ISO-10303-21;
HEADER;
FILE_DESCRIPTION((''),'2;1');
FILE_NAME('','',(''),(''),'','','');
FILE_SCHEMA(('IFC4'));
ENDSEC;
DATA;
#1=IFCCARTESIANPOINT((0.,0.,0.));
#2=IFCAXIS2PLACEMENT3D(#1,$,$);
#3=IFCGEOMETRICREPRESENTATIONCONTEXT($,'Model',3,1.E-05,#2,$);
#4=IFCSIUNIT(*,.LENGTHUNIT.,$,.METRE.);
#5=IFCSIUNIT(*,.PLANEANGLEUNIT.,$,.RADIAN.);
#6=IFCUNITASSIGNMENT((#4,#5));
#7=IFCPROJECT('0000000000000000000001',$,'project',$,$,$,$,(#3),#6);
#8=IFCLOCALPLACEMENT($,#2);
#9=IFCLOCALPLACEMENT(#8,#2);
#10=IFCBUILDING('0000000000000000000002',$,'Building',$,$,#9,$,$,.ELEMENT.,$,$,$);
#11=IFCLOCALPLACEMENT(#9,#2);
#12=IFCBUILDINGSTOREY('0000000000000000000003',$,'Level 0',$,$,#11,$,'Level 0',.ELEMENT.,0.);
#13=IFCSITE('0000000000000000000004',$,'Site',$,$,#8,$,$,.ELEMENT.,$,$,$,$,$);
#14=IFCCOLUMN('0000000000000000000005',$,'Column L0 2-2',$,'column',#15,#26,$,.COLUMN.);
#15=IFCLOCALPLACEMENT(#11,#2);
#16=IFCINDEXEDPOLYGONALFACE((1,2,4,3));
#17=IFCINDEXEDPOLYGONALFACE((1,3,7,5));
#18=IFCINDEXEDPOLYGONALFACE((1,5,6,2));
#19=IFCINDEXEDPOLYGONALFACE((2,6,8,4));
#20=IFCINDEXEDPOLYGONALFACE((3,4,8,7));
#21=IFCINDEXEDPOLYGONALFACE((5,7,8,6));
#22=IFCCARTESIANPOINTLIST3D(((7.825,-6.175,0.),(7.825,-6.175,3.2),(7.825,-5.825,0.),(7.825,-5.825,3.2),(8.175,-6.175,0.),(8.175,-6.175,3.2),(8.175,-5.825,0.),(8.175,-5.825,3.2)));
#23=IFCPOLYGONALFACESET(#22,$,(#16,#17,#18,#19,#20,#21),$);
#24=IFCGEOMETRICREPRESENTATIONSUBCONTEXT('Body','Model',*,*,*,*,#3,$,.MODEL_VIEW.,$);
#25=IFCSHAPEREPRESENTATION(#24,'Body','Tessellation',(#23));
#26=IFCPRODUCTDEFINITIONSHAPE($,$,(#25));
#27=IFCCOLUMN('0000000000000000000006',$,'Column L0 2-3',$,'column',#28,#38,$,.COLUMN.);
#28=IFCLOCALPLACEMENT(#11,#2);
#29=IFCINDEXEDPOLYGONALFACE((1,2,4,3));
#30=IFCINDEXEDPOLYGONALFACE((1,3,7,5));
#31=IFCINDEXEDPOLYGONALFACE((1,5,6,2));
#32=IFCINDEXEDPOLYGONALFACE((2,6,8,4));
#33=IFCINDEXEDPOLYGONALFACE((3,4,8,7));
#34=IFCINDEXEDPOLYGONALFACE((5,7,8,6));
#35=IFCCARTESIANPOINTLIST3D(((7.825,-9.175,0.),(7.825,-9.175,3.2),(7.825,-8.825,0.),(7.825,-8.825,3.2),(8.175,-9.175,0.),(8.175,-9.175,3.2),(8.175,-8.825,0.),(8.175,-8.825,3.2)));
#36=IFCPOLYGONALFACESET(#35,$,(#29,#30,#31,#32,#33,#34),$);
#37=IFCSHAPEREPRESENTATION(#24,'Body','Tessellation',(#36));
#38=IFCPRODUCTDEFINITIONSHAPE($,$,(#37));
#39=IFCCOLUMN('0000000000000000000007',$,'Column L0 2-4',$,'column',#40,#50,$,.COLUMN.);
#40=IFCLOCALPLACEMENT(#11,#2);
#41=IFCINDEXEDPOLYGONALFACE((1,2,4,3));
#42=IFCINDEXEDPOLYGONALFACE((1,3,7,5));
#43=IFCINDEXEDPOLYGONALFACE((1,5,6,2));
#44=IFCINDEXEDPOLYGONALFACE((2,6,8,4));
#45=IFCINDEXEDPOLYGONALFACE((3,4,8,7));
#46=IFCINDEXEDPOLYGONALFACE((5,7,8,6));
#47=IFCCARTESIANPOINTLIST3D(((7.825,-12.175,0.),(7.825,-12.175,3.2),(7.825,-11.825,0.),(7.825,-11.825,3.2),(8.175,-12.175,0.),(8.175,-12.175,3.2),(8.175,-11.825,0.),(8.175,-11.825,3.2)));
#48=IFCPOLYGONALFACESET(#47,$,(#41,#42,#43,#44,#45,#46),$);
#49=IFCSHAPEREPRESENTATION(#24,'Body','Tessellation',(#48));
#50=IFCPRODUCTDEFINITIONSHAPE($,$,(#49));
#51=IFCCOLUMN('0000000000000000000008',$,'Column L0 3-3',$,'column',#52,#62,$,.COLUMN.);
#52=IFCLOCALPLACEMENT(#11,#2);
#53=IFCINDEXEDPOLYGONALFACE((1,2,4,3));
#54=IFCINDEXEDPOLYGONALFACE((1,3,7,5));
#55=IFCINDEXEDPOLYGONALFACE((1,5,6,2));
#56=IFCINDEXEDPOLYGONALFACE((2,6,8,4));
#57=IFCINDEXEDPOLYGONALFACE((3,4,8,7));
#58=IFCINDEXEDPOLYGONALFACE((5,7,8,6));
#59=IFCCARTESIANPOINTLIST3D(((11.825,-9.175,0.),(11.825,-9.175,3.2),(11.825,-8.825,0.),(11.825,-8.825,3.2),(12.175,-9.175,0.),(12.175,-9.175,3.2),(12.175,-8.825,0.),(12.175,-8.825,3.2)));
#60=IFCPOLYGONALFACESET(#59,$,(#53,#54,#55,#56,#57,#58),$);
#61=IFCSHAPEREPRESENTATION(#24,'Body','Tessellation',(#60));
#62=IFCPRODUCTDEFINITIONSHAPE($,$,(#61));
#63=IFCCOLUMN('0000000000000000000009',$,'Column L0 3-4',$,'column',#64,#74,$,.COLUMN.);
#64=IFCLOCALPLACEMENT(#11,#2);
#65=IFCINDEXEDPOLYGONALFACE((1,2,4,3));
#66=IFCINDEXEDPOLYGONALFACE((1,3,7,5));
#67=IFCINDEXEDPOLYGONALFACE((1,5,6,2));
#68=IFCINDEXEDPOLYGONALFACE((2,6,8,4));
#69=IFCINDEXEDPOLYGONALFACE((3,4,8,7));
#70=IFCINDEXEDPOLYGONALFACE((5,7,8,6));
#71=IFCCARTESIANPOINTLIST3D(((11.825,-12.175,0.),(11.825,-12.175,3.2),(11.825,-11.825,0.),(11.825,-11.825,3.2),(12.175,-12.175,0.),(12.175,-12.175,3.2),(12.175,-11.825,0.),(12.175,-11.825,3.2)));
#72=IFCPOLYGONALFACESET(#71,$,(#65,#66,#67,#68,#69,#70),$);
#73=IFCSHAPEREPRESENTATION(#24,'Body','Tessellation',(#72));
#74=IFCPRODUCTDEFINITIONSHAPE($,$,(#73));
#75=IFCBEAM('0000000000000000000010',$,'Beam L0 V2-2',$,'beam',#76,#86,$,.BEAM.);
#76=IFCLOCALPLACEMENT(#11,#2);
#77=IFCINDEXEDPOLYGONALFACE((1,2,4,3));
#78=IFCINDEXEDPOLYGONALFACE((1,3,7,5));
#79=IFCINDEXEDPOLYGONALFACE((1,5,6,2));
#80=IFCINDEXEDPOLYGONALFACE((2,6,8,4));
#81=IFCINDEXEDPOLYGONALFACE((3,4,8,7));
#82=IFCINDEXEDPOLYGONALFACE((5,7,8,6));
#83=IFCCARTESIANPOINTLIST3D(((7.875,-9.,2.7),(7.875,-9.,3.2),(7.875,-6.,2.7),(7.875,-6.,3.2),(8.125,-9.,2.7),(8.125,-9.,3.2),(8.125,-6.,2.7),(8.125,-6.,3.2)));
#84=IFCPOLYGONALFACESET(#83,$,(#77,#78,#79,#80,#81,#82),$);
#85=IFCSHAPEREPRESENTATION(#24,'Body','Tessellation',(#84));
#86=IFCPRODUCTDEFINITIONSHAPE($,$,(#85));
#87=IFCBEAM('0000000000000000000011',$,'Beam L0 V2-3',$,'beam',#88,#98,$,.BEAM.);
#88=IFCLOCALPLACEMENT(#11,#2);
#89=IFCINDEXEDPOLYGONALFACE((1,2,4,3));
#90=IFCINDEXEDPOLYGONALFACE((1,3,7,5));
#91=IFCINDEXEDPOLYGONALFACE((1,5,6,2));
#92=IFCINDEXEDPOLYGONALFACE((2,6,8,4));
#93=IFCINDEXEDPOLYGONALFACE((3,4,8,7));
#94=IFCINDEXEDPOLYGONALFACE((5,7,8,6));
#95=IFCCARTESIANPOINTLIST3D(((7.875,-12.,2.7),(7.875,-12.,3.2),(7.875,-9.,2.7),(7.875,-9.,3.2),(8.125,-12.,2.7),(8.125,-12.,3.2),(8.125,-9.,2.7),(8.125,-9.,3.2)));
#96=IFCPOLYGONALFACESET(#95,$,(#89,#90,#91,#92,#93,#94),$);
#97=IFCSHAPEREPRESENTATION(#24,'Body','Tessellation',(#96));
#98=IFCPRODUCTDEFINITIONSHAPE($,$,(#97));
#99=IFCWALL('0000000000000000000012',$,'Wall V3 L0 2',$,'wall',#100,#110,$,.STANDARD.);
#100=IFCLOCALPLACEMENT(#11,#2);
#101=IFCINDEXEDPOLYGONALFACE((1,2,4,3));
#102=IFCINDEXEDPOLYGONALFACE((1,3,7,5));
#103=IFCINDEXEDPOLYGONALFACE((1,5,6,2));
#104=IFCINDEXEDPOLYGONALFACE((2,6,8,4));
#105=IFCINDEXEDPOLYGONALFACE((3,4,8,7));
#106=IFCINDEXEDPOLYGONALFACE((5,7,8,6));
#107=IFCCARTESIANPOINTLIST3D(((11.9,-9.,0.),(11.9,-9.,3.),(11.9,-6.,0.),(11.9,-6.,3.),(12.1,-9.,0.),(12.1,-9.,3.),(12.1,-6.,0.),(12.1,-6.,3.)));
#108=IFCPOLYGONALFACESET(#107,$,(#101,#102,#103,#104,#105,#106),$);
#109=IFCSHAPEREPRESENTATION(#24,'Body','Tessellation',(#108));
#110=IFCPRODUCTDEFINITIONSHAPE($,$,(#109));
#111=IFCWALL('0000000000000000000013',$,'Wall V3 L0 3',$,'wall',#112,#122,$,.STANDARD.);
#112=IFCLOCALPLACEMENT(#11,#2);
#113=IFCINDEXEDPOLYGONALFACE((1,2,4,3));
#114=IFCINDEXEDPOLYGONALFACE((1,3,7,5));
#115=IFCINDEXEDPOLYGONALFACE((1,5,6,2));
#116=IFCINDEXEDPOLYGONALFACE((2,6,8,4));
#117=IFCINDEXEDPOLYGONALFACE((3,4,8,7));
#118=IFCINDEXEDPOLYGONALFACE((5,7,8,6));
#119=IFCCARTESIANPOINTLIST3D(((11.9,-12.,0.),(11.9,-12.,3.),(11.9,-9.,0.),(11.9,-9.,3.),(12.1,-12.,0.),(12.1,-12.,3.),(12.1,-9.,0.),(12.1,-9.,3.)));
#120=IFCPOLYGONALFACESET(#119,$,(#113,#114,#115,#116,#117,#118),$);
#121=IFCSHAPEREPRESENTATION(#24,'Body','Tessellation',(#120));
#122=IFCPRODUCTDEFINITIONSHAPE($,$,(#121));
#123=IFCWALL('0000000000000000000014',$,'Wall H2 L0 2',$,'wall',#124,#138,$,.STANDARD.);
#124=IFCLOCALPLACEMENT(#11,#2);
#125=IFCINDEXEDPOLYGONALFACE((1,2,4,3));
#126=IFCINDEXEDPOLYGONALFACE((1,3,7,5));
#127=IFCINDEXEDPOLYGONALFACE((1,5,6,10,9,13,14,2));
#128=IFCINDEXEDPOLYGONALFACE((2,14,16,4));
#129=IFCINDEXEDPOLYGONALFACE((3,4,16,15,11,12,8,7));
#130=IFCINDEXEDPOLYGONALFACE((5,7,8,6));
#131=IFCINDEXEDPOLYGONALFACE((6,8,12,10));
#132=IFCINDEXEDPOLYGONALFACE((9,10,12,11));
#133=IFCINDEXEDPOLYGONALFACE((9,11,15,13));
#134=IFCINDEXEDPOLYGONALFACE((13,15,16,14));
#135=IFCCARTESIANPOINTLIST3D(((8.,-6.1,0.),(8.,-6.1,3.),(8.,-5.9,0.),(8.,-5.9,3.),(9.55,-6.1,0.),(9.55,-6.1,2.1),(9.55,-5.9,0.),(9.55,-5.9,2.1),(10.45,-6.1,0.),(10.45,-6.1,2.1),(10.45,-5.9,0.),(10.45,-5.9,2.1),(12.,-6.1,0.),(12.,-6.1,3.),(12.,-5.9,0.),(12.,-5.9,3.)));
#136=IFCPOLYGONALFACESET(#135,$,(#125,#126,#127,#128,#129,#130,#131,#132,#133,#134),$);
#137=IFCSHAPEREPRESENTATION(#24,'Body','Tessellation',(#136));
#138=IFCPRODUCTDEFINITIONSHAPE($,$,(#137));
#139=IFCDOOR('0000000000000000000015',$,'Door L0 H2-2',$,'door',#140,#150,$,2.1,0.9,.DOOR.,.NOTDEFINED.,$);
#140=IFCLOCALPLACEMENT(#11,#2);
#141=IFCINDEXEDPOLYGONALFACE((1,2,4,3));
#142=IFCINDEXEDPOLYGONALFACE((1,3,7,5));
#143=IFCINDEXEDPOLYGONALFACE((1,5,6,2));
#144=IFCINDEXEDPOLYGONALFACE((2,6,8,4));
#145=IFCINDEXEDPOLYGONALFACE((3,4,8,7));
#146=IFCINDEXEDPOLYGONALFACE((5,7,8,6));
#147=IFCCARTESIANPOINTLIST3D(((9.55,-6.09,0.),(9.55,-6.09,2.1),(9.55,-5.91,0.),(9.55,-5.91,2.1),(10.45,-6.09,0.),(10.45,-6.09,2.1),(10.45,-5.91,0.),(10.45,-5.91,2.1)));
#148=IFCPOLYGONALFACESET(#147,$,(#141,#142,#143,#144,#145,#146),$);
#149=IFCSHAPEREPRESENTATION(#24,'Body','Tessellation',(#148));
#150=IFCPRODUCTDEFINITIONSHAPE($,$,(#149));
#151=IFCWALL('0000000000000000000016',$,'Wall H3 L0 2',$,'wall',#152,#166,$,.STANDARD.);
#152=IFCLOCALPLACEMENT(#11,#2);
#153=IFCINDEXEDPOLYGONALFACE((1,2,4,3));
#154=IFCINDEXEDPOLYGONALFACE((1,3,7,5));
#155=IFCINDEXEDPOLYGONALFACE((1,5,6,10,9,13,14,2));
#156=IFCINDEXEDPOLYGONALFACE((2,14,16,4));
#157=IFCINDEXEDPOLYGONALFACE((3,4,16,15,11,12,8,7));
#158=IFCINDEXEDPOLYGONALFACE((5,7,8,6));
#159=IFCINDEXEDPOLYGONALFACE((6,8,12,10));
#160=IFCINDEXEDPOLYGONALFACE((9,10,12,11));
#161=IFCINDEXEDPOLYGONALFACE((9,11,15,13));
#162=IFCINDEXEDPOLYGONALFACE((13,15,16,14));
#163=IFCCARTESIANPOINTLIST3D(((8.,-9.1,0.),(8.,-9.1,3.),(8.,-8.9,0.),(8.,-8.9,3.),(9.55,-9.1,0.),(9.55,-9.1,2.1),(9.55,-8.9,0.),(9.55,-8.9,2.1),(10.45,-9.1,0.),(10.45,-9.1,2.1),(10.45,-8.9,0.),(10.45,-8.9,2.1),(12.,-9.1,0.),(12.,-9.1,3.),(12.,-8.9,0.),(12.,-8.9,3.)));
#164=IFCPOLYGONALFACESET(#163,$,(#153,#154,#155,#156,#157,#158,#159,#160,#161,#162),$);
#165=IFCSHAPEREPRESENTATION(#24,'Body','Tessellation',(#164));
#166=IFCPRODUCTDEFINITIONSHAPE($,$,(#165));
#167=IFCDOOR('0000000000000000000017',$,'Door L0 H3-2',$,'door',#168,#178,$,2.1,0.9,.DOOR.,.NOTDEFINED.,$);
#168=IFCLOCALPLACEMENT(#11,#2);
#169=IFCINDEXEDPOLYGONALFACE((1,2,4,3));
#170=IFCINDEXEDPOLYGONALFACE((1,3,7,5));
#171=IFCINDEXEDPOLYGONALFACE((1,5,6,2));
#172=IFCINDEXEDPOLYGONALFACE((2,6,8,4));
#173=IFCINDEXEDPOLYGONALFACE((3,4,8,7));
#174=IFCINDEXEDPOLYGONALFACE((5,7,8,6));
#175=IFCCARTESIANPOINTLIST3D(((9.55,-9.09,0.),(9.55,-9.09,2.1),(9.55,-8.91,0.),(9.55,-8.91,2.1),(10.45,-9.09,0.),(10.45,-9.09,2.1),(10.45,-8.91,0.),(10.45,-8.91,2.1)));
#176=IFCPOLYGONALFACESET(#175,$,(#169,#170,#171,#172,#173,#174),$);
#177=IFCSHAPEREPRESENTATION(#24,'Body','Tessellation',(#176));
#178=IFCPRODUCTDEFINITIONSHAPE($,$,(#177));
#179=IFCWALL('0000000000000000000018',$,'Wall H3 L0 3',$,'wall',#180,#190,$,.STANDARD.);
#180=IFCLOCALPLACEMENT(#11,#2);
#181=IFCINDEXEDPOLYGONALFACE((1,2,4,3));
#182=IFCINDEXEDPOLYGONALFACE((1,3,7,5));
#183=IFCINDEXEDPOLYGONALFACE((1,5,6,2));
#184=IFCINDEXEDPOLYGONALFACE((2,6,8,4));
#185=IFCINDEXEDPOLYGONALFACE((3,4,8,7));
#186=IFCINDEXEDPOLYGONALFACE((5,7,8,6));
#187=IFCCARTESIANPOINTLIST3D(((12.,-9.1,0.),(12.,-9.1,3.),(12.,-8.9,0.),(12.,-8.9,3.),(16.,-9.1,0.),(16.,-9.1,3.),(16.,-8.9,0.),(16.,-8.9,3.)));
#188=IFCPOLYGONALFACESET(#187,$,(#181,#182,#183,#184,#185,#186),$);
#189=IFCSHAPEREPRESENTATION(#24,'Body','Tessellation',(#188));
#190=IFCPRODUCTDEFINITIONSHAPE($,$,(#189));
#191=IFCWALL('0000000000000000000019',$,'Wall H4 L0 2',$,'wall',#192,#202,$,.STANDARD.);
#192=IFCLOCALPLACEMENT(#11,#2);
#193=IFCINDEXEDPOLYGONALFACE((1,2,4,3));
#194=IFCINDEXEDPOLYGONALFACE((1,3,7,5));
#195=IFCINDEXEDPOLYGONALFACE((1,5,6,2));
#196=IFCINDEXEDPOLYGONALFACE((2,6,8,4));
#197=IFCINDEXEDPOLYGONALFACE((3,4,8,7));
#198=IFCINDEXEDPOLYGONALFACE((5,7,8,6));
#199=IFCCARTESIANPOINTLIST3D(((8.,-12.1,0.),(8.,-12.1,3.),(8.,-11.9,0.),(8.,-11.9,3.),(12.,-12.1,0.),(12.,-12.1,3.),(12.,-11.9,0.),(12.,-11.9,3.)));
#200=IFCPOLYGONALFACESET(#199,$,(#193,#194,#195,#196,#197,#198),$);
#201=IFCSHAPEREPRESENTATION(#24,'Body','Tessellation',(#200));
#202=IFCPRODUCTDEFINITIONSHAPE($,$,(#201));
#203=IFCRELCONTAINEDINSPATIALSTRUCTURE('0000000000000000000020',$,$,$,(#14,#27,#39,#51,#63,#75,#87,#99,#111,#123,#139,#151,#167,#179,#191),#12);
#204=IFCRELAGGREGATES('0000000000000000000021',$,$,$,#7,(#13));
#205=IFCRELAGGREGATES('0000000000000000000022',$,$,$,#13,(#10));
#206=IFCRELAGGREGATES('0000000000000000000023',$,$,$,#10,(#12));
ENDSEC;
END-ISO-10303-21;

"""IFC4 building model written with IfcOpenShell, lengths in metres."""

from ifc_helpers import new_model, si_unit, frame, frame_2d, origin, origin_2d, place, context, subcontext, project, spatial, rectangle, extrude, element, fill, save


model = new_model("IFC4")

# Units and contexts
model_context = context("Model", 3, precision=1e-05, world=origin())
body_context = subcontext(model_context, "Body", "Model", "MODEL_VIEW")
ifc_project = project(units=[si_unit("LENGTHUNIT", "METRE"), si_unit("PLANEANGLEUNIT", "RADIAN")], contexts=[model_context])

# Site, building, storey
site_placement = place(None, origin())
site = spatial("IfcSite", under=ifc_project, at=site_placement, Name="Site", CompositionType="ELEMENT")
building_placement = place(site_placement, origin())
building = spatial("IfcBuilding", under=site, at=building_placement, Name="Building", CompositionType="ELEMENT")
storey_placement = place(building_placement, origin())
storey = spatial("IfcBuildingStorey", under=building, at=storey_placement, Name="Level 0", LongName="Level 0", CompositionType="ELEMENT", Elevation=0.0)

# Columns
for number, where, name in (
    (1, (8.0, -6.0, 0.0), "Column L0 2-2"),
    (2, (8.0, -9.0, 0.0), "Column L0 2-3"),
    (3, (8.0, -12.0, 0.0), "Column L0 2-4"),
    (4, (12.0, -9.0, 0.0), "Column L0 3-3"),
    (5, (12.0, -12.0, 0.0), "Column L0 3-4"),
):
    element("IfcColumn", number, at=place(storey_placement, frame(where)), inside=storey, Name=name, ObjectType="column", PredefinedType="COLUMN", context=body_context, shape_type="SweptSolid", body=[
        extrude(rectangle(XDim=0.35, YDim=0.35, at=origin_2d()), origin(), (0.0, 0.0, 1.0), 3.2),
    ])

# Beams
for number, where, z_axis, x_axis, name in (
    (6, (8.0, -6.0, 2.95), (0.0, -1.0, 0.0), (0.0, 0.0, 1.0), "Beam L0 V2-2"),
    (7, (8.0, -9.0, 2.95), (0.0, -1.0, 0.0), (0.0, 0.0, 1.0), "Beam L0 V2-3"),
):
    element("IfcBeam", number, at=place(storey_placement, frame(where, z_axis=z_axis, x_axis=x_axis)), inside=storey, Name=name, ObjectType="beam", PredefinedType="BEAM", context=body_context, shape_type="SweptSolid", body=[
        extrude(rectangle(XDim=0.5, YDim=0.25, at=origin_2d()), origin(), (0.0, 0.0, 1.0), 3.0),
    ])

# Walls
for number, where, z_axis, x_axis, name in (
    (8, (12.0, -6.0, 0.0), (0.0, 0.0, 1.0), (0.0, -1.0, 0.0), "Wall V3 L0 2"),
    (9, (12.0, -9.0, 0.0), (0.0, 0.0, 1.0), (0.0, -1.0, 0.0), "Wall V3 L0 3"),
):
    element("IfcWall", number, at=place(storey_placement, frame(where, z_axis=z_axis, x_axis=x_axis)), inside=storey, Name=name, ObjectType="wall", PredefinedType="STANDARD", context=body_context, shape_type="SweptSolid", body=[
        extrude(rectangle(XDim=3.0, YDim=0.2, at=frame_2d((1.5, 0.0))), origin(), (0.0, 0.0, 1.0), 3.0),
    ])

# Walls, openings, doors
wall_1_placement = place(storey_placement, frame((8.0, -6.0, 0.0), z_axis=(0.0, 0.0, 1.0), x_axis=(1.0, 0.0, 0.0)))
wall_1 = element("IfcWall", 10, at=wall_1_placement, inside=storey, Name="Wall H2 L0 2", ObjectType="wall", PredefinedType="STANDARD", context=body_context, shape_type="SweptSolid", body=[
    extrude(rectangle(XDim=4.0, YDim=0.2, at=frame_2d((2.0, 0.0))), origin(), (0.0, 0.0, 1.0), 3.0),
])
opening_1_placement = place(storey_placement, frame((10.0, -6.0, 0.0), z_axis=(0.0, 0.0, 1.0), x_axis=(1.0, 0.0, 0.0)))
opening_1 = element("IfcOpeningElement", 11, at=opening_1_placement, cuts=wall_1, ObjectType="Opening", PredefinedType="OPENING", context=body_context, shape_type="SweptSolid", body=[
    extrude(rectangle(XDim=0.9, YDim=0.22, at=origin_2d()), origin(), (0.0, 0.0, 1.0), 2.1),
])
door_1_placement = place(storey_placement, frame((10.0, -6.0, 0.0), z_axis=(0.0, 0.0, 1.0), x_axis=(1.0, 0.0, 0.0)))
door_1 = element("IfcDoor", 12, at=door_1_placement, inside=storey, Name="Door L0 H2-2", ObjectType="door", OperationType="NOTDEFINED", OverallHeight=2.1, OverallWidth=0.9, PredefinedType="DOOR", context=body_context, shape_type="SweptSolid", body=[
    extrude(rectangle(XDim=0.9, YDim=0.18, at=origin_2d()), origin(), (0.0, 0.0, 1.0), 2.1),
])
fill(opening_1, door_1)
wall_2_placement = place(storey_placement, frame((8.0, -9.0, 0.0), z_axis=(0.0, 0.0, 1.0), x_axis=(1.0, 0.0, 0.0)))
wall_2 = element("IfcWall", 13, at=wall_2_placement, inside=storey, Name="Wall H3 L0 2", ObjectType="wall", PredefinedType="STANDARD", context=body_context, shape_type="SweptSolid", body=[
    extrude(rectangle(XDim=4.0, YDim=0.2, at=frame_2d((2.0, 0.0))), origin(), (0.0, 0.0, 1.0), 3.0),
])
opening_2_placement = place(storey_placement, frame((10.0, -9.0, 0.0), z_axis=(0.0, 0.0, 1.0), x_axis=(1.0, 0.0, 0.0)))
opening_2 = element("IfcOpeningElement", 14, at=opening_2_placement, cuts=wall_2, ObjectType="Opening", PredefinedType="OPENING", context=body_context, shape_type="SweptSolid", body=[
    extrude(rectangle(XDim=0.9, YDim=0.22, at=origin_2d()), origin(), (0.0, 0.0, 1.0), 2.1),
])
door_2_placement = place(storey_placement, frame((10.0, -9.0, 0.0), z_axis=(0.0, 0.0, 1.0), x_axis=(1.0, 0.0, 0.0)))
door_2 = element("IfcDoor", 15, at=door_2_placement, inside=storey, Name="Door L0 H3-2", ObjectType="door", OperationType="NOTDEFINED", OverallHeight=2.1, OverallWidth=0.9, PredefinedType="DOOR", context=body_context, shape_type="SweptSolid", body=[
    extrude(rectangle(XDim=0.9, YDim=0.18, at=origin_2d()), origin(), (0.0, 0.0, 1.0), 2.1),
])
fill(opening_2, door_2)

# Walls
for number, where, z_axis, x_axis, name in (
    (16, (12.0, -9.0, 0.0), (0.0, 0.0, 1.0), (1.0, 0.0, 0.0), "Wall H3 L0 3"),
    (17, (8.0, -12.0, 0.0), (0.0, 0.0, 1.0), (1.0, 0.0, 0.0), "Wall H4 L0 2"),
):
    element("IfcWall", number, at=place(storey_placement, frame(where, z_axis=z_axis, x_axis=x_axis)), inside=storey, Name=name, ObjectType="wall", PredefinedType="STANDARD", context=body_context, shape_type="SweptSolid", body=[
        extrude(rectangle(XDim=4.0, YDim=0.2, at=frame_2d((2.0, 0.0))), origin(), (0.0, 0.0, 1.0), 3.0),
    ])

save(model, "model.ifc")
